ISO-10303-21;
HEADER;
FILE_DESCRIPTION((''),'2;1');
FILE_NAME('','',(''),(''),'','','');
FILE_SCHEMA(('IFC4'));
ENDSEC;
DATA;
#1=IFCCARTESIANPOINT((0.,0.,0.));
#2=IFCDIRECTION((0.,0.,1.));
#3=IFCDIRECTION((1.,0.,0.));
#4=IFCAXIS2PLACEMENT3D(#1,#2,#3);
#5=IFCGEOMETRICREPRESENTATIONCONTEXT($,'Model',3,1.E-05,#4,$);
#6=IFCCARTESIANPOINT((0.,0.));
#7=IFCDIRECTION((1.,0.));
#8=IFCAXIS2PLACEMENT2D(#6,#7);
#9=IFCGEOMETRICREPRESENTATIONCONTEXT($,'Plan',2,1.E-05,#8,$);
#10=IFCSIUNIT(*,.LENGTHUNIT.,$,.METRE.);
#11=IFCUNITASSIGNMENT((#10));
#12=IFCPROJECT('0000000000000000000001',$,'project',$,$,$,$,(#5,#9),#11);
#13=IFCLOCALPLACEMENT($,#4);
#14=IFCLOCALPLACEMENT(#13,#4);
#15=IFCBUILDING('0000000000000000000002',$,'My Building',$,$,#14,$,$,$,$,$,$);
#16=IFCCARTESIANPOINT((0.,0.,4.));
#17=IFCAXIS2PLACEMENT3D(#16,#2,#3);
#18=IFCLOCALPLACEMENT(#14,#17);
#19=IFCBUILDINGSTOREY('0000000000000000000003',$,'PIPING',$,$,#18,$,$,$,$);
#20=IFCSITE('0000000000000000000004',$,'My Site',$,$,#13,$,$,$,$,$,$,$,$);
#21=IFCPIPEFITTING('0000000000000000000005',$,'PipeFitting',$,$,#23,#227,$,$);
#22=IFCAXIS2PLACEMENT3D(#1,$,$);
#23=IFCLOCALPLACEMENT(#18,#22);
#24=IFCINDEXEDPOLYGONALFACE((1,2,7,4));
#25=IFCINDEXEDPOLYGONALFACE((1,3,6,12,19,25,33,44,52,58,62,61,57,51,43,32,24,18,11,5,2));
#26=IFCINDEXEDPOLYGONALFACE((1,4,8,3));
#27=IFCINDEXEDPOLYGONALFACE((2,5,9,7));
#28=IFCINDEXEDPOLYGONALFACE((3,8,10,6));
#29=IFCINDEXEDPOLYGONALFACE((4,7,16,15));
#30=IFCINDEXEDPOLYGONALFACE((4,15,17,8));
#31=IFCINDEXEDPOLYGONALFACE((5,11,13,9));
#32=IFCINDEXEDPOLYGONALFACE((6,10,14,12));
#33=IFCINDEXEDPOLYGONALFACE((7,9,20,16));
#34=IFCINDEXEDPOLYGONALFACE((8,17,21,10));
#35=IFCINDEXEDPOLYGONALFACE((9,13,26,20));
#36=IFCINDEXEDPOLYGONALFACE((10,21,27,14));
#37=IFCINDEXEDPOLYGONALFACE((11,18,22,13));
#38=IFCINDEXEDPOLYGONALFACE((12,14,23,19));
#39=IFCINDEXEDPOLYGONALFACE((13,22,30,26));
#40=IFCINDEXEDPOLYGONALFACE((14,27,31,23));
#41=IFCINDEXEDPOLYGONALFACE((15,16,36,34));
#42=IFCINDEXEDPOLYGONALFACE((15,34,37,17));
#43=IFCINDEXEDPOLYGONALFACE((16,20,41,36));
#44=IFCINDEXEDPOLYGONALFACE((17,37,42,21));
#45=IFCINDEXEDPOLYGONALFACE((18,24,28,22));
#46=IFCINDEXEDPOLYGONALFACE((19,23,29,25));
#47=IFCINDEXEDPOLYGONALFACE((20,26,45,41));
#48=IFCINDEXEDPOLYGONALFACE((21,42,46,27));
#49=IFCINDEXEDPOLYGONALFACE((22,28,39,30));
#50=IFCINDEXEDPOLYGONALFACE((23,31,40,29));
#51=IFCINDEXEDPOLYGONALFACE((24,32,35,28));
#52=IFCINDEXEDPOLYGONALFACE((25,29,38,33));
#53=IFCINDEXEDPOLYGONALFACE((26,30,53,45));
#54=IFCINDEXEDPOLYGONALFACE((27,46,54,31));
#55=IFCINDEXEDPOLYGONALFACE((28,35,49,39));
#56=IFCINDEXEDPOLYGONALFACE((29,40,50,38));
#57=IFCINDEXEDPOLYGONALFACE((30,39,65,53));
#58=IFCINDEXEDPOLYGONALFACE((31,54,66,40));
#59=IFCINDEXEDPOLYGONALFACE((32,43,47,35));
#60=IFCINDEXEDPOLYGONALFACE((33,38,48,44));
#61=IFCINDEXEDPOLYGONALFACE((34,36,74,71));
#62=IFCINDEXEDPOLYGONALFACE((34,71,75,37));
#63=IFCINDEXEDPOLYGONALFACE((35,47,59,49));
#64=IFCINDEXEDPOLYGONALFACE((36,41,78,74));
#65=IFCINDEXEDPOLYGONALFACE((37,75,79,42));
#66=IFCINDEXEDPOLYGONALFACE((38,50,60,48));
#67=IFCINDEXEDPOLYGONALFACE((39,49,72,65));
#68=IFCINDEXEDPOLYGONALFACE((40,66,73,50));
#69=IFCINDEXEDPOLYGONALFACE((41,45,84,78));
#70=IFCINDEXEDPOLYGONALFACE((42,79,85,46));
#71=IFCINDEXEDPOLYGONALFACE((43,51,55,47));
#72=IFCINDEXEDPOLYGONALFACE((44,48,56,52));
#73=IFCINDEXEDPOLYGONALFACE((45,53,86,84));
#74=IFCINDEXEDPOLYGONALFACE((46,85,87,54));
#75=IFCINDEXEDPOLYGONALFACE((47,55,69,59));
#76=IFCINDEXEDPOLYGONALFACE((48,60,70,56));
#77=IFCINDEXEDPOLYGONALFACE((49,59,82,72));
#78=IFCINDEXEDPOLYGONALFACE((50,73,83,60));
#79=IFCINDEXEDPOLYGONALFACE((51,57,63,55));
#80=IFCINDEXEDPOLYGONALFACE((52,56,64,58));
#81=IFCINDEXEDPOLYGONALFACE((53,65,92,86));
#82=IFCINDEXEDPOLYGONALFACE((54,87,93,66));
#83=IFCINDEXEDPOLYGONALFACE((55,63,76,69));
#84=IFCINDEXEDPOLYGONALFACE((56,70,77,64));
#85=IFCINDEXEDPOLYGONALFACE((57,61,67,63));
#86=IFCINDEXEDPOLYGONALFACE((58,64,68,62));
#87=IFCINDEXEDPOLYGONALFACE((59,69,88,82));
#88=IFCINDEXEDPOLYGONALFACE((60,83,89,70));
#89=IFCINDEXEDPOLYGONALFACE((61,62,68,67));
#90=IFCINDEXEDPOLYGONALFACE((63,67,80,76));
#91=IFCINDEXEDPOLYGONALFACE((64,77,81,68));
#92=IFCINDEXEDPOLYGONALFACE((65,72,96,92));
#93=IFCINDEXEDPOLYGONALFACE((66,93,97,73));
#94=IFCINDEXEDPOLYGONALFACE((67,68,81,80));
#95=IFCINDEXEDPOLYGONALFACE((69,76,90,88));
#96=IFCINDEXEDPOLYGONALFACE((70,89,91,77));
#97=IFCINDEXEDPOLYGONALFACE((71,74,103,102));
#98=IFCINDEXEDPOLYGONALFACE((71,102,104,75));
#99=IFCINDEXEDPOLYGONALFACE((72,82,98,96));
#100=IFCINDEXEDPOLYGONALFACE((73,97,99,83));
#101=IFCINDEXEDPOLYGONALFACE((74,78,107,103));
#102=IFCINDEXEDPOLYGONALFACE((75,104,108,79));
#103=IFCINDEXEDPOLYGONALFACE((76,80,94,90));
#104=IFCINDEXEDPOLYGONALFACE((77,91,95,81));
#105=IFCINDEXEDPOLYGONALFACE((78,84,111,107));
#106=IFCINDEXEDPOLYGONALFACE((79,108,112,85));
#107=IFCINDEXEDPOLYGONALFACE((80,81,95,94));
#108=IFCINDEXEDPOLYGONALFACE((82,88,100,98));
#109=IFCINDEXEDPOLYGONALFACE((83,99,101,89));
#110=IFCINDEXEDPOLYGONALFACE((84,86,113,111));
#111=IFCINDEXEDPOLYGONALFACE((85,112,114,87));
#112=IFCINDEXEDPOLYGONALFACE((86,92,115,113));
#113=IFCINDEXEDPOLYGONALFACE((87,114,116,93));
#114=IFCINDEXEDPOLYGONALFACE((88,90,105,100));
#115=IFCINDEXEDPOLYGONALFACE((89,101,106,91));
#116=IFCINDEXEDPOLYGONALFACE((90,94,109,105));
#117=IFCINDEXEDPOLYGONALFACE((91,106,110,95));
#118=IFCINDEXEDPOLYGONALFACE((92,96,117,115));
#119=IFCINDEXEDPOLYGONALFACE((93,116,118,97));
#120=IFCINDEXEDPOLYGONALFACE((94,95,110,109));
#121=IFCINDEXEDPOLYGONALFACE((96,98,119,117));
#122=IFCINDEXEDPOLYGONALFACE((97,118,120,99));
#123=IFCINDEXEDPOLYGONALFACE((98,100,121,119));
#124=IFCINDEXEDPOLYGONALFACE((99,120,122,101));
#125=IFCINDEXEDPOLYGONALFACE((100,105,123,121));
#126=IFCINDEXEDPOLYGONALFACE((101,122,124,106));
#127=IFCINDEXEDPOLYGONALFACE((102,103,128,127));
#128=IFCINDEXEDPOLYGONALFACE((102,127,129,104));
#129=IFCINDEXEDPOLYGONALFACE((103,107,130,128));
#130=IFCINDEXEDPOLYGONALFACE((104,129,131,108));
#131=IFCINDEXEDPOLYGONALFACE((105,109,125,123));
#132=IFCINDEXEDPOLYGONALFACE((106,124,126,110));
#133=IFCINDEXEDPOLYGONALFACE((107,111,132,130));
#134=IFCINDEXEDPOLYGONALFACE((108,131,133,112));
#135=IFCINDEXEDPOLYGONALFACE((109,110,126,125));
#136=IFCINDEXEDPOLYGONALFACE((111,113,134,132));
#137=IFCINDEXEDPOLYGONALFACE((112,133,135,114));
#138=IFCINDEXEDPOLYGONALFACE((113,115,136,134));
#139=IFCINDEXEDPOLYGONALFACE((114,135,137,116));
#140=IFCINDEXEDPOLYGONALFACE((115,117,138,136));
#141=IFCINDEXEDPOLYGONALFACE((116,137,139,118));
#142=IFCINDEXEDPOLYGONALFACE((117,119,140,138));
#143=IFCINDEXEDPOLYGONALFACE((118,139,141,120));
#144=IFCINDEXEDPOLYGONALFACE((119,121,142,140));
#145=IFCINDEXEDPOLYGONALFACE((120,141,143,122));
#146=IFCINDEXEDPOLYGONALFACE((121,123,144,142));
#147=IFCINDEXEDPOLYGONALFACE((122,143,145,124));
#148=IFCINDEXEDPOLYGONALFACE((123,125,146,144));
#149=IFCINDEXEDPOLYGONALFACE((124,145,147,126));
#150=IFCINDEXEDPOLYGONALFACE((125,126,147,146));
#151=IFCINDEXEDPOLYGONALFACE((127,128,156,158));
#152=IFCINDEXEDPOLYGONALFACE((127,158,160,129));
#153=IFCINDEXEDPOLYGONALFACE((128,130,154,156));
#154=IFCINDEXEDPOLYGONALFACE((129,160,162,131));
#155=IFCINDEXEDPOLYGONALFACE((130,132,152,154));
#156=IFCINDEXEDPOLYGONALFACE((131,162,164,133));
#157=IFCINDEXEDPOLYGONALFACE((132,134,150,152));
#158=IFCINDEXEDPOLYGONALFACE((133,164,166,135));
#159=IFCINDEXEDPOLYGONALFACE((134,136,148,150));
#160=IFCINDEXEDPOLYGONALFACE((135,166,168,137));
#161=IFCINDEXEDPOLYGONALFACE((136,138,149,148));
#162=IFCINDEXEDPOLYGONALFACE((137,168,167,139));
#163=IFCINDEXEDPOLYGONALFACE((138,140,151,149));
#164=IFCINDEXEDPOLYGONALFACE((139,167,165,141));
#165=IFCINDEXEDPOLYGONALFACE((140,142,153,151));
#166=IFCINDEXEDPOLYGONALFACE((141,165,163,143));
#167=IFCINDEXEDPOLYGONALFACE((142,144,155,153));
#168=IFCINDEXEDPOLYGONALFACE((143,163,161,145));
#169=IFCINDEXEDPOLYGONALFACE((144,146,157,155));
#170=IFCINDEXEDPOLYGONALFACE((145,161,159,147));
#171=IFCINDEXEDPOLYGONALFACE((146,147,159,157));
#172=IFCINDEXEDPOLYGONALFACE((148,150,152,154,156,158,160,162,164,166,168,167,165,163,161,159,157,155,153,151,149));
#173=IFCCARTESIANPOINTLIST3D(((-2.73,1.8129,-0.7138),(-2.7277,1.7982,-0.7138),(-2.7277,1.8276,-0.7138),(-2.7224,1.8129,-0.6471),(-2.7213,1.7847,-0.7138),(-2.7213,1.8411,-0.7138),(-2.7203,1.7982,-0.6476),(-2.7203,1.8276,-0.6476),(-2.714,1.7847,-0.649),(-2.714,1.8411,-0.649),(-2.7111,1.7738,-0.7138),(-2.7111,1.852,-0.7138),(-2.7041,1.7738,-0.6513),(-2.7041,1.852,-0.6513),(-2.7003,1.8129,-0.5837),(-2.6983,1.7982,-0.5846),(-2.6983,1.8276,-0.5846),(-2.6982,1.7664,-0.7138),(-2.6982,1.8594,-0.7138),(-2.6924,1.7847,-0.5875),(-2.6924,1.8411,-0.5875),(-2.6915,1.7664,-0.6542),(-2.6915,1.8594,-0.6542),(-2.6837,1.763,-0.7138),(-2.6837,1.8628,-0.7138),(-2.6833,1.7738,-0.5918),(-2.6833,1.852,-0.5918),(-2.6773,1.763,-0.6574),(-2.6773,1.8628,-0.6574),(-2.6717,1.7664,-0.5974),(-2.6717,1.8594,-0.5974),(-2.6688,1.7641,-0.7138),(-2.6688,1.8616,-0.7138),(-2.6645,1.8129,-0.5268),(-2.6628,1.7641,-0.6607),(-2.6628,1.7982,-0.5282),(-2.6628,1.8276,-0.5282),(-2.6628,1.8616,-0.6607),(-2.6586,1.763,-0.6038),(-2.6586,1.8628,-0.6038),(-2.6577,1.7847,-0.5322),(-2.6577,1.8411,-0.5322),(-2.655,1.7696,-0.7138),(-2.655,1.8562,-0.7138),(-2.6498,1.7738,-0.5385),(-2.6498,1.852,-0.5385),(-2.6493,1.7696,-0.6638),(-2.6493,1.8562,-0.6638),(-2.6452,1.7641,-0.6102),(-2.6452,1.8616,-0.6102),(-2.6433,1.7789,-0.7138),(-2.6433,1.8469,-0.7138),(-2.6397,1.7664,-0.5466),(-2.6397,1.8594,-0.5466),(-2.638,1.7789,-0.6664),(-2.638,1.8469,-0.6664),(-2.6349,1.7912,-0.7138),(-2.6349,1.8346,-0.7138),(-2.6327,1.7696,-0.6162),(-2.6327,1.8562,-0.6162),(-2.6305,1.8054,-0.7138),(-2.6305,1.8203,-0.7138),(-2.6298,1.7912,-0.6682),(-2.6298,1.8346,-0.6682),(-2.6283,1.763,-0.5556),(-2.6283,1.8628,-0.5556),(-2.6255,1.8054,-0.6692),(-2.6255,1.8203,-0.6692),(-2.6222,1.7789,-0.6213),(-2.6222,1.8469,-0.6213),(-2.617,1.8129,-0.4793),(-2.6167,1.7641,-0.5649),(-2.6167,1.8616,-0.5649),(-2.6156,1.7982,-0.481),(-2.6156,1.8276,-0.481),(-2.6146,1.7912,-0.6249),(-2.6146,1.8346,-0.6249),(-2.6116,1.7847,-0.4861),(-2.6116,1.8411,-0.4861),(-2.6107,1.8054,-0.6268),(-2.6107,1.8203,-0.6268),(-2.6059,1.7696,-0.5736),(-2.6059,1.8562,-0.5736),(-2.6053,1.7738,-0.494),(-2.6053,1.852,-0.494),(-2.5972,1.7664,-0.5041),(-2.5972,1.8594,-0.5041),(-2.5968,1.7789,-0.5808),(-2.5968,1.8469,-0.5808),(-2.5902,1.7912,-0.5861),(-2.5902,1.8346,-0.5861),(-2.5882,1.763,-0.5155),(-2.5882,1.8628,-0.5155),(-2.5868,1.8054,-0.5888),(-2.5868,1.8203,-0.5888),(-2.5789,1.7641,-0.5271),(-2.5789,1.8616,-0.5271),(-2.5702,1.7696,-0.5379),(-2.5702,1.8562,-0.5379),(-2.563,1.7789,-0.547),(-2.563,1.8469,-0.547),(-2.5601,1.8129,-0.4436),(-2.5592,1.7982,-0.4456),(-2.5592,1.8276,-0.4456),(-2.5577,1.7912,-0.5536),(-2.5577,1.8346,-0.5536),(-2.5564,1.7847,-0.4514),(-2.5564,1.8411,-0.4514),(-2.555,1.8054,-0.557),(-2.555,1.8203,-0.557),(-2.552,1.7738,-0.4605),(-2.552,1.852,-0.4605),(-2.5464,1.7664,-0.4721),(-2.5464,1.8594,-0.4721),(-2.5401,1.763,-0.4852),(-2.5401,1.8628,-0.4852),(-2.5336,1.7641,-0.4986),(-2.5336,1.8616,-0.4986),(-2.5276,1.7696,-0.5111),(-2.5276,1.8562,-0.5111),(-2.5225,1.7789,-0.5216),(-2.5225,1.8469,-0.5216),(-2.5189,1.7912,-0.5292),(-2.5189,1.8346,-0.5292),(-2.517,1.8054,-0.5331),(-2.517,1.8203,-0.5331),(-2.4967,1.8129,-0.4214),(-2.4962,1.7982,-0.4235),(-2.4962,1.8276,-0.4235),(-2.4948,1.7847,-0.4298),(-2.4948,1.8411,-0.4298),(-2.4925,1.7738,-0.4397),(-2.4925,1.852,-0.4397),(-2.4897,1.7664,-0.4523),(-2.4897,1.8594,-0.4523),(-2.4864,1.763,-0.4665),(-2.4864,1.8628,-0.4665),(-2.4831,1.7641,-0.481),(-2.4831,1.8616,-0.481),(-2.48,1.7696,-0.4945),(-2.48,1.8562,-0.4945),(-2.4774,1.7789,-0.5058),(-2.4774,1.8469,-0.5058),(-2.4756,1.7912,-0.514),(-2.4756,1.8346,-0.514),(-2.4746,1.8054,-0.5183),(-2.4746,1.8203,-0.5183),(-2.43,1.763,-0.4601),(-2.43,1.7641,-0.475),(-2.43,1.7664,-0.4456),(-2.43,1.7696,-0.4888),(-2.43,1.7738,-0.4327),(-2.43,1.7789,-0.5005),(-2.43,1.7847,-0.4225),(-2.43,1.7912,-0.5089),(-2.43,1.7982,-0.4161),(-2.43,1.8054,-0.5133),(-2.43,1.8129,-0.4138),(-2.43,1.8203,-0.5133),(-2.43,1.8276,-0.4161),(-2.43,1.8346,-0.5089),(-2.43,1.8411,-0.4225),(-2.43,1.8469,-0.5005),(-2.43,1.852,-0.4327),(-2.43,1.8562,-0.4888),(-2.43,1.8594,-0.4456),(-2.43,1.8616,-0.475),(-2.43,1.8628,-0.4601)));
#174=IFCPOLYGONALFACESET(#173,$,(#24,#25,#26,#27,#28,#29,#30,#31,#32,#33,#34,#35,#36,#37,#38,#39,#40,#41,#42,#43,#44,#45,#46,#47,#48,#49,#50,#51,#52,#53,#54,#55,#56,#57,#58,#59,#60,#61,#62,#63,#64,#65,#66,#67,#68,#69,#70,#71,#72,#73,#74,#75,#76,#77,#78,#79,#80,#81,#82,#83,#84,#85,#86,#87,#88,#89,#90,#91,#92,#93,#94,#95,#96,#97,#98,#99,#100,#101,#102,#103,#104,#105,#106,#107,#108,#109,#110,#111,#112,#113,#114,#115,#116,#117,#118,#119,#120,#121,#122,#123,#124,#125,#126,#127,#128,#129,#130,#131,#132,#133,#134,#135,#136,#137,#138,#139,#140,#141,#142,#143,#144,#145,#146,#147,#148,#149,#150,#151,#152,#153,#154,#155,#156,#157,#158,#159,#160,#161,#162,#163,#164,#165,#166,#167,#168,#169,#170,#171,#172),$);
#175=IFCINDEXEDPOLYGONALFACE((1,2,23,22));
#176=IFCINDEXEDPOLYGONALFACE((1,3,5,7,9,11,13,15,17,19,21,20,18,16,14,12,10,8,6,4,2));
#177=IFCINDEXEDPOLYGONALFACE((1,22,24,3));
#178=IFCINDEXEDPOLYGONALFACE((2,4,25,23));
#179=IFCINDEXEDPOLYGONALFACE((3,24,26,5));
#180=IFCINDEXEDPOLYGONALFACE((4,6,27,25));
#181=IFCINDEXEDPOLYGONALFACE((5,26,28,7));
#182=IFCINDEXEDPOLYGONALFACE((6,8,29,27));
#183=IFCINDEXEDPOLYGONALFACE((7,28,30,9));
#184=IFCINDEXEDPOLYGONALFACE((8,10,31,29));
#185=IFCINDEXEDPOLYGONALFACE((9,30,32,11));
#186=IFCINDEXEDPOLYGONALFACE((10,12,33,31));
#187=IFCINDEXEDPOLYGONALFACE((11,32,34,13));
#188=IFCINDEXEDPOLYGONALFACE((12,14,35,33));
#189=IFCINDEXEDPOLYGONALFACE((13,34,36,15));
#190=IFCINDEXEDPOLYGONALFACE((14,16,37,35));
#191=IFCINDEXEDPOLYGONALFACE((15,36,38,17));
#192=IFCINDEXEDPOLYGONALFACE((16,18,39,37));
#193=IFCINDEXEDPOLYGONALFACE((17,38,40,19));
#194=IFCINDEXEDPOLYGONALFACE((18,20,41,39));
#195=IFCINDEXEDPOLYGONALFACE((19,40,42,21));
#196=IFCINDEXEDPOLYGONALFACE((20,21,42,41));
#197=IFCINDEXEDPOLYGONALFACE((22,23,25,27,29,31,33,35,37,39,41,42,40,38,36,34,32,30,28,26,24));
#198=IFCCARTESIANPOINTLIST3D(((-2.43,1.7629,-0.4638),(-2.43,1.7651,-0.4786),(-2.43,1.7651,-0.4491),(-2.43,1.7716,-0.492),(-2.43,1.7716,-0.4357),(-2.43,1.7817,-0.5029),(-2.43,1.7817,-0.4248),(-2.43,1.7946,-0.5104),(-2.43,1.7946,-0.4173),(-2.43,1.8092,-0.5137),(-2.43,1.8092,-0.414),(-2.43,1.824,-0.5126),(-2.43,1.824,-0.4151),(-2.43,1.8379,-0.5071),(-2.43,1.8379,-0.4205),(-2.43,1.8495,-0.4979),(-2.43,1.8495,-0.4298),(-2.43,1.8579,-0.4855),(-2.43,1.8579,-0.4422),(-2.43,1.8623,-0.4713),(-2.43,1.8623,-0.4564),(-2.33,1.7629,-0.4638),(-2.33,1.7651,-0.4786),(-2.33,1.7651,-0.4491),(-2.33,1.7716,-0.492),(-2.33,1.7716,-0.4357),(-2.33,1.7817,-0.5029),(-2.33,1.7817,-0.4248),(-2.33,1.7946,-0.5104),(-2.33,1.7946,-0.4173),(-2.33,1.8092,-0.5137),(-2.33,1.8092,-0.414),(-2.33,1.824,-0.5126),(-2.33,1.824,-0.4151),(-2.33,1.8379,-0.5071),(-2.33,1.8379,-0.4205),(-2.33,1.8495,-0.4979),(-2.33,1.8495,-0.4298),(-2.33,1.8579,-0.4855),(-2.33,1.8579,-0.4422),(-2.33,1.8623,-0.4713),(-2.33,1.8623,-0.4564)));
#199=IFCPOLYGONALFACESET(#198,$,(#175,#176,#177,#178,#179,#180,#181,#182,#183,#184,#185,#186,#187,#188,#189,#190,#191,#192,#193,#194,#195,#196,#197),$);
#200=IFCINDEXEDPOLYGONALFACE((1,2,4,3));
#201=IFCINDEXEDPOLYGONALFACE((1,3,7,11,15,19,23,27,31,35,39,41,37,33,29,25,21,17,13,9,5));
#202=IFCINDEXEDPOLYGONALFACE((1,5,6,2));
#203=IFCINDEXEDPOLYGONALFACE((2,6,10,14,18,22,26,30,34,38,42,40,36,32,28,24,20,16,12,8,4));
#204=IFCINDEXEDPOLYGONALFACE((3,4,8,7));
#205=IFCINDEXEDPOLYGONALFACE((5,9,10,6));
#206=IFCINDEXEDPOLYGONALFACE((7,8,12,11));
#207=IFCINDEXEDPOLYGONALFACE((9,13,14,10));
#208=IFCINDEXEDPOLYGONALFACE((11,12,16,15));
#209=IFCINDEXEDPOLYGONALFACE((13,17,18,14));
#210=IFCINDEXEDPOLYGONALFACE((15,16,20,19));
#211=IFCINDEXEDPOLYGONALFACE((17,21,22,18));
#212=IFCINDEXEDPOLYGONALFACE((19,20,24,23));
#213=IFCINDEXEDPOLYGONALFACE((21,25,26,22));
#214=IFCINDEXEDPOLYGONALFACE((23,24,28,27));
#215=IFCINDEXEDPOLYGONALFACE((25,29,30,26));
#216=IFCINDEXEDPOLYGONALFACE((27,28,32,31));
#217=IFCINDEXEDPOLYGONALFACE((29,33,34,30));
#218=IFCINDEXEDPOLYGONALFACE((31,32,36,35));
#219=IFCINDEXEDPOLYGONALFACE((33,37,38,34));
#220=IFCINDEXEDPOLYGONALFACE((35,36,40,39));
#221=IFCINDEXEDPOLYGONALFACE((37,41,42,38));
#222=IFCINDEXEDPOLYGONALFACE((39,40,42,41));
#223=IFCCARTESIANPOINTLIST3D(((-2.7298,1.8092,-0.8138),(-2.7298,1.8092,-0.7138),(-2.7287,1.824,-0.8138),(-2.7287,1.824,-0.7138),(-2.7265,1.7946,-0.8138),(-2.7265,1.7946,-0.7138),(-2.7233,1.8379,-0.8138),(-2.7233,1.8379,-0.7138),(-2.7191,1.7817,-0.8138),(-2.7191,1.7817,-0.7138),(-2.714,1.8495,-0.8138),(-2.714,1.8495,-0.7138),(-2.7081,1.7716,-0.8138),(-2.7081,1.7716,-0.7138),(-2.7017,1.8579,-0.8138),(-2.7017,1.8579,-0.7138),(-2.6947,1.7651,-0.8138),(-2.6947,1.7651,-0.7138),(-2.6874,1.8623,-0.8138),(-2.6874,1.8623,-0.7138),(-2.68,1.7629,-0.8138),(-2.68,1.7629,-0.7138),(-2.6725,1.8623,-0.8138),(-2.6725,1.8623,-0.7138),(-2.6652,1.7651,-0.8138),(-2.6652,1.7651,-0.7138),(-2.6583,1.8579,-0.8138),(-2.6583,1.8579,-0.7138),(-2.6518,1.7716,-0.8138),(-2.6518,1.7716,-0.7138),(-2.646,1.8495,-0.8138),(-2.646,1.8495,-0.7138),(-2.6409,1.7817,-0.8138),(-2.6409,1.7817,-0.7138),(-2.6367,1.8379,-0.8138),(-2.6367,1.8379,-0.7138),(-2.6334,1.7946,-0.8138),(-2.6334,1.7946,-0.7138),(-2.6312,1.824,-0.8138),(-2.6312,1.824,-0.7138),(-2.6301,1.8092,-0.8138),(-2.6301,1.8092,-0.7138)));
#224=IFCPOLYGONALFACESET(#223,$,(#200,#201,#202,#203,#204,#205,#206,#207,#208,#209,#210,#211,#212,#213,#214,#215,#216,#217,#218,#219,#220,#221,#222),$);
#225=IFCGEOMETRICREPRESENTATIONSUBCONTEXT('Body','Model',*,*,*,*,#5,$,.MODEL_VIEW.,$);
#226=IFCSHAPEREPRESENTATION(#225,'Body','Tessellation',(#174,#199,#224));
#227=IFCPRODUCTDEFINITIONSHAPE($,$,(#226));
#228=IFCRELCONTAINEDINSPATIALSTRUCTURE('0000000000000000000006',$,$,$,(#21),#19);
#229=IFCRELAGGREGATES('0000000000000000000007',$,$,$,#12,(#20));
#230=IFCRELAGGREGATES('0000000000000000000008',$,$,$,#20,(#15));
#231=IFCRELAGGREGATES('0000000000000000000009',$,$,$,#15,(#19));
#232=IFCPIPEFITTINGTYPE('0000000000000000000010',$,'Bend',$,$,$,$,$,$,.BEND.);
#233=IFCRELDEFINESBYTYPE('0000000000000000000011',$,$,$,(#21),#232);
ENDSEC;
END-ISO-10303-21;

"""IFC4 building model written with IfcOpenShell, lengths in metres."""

from ifc_helpers import new_model, entity, si_unit, frame, origin_with_axes, origin_2d_with_axis, place, context, subcontext, project, spatial, circle, extrude, source, transform, mapped, type_object, type_shapes, element, save


model = new_model("IFC4")

# Units and contexts
model_context = context("Model", 3, precision=1e-05, world=origin_with_axes())
plan_context = context("Plan", 2, precision=1e-05, world=origin_2d_with_axis())
body_context = subcontext(model_context, "Body", "Model", "MODEL_VIEW")
ifc_project = project(units=[si_unit("LENGTHUNIT", "METRE")], contexts=[model_context, plan_context])

# Site, building, storey
site_placement = place(None, origin_with_axes())
site = spatial("IfcSite", under=ifc_project, at=site_placement, Name="My Site")
building_placement = place(site_placement, origin_with_axes())
building = spatial("IfcBuilding", under=site, at=building_placement, Name="My Building")
storey_placement = place(building_placement, frame((0.0, 0.0, 4.0), z_axis=(0.0, 0.0, 1.0), x_axis=(1.0, 0.0, 0.0)))
storey = spatial("IfcBuildingStorey", under=building, at=storey_placement, Name="PIPING")

# Pipe fitting
pipe_fitting_type = type_object("IfcPipeFittingType", Name="Bend", PredefinedType="BEND")
shared_shape = source(origin_with_axes(), body_context, "Body", "SolidModel", [
    entity("IfcSweptDiskSolid", entity("IfcIndexedPolyCurve", entity("IfcCartesianPointList3D", [[0.0, 0.0, 0.1], [0.0, -0.0732, 0.2768], [0.0, -0.25, 0.35]]), [entity("IfcArcIndex", [1, 2, 3])]), 0.05),
    extrude(circle(Radius=0.05), origin_with_axes(), (0.0, 0.0, 1.0), 0.1),
    extrude(circle(Radius=0.05), frame((0.0, -0.25, 0.35), z_axis=(0.0, -1.0, 0.0), x_axis=(1.0, 0.0, 0.0)), (0.0, 0.0, 1.0), 0.1),
])
type_shapes(pipe_fitting_type, [shared_shape])
for number, where, z_axis, x_axis, name in (
    (1, (-2.33, 1.8129, -0.4638), (-1.0, 0.0, 0.0), (0.0, -1.0, 0.0), "PipeFitting"),
):
    element("IfcPipeFitting", number, at=place(storey_placement, frame(where, z_axis=z_axis, x_axis=x_axis)), inside=storey, type_object=pipe_fitting_type, Name=name, context=body_context, shape_type="MappedRepresentation", body=[
        mapped(shared_shape, transform((0.0, 0.0, 0.0), x_axis=(1.0, 0.0, 0.0), y_axis=(0.0, 1.0, 0.0), z_axis=(0.0, 0.0, 1.0), scale=1.0)),
    ])

save(model, "model.ifc")
